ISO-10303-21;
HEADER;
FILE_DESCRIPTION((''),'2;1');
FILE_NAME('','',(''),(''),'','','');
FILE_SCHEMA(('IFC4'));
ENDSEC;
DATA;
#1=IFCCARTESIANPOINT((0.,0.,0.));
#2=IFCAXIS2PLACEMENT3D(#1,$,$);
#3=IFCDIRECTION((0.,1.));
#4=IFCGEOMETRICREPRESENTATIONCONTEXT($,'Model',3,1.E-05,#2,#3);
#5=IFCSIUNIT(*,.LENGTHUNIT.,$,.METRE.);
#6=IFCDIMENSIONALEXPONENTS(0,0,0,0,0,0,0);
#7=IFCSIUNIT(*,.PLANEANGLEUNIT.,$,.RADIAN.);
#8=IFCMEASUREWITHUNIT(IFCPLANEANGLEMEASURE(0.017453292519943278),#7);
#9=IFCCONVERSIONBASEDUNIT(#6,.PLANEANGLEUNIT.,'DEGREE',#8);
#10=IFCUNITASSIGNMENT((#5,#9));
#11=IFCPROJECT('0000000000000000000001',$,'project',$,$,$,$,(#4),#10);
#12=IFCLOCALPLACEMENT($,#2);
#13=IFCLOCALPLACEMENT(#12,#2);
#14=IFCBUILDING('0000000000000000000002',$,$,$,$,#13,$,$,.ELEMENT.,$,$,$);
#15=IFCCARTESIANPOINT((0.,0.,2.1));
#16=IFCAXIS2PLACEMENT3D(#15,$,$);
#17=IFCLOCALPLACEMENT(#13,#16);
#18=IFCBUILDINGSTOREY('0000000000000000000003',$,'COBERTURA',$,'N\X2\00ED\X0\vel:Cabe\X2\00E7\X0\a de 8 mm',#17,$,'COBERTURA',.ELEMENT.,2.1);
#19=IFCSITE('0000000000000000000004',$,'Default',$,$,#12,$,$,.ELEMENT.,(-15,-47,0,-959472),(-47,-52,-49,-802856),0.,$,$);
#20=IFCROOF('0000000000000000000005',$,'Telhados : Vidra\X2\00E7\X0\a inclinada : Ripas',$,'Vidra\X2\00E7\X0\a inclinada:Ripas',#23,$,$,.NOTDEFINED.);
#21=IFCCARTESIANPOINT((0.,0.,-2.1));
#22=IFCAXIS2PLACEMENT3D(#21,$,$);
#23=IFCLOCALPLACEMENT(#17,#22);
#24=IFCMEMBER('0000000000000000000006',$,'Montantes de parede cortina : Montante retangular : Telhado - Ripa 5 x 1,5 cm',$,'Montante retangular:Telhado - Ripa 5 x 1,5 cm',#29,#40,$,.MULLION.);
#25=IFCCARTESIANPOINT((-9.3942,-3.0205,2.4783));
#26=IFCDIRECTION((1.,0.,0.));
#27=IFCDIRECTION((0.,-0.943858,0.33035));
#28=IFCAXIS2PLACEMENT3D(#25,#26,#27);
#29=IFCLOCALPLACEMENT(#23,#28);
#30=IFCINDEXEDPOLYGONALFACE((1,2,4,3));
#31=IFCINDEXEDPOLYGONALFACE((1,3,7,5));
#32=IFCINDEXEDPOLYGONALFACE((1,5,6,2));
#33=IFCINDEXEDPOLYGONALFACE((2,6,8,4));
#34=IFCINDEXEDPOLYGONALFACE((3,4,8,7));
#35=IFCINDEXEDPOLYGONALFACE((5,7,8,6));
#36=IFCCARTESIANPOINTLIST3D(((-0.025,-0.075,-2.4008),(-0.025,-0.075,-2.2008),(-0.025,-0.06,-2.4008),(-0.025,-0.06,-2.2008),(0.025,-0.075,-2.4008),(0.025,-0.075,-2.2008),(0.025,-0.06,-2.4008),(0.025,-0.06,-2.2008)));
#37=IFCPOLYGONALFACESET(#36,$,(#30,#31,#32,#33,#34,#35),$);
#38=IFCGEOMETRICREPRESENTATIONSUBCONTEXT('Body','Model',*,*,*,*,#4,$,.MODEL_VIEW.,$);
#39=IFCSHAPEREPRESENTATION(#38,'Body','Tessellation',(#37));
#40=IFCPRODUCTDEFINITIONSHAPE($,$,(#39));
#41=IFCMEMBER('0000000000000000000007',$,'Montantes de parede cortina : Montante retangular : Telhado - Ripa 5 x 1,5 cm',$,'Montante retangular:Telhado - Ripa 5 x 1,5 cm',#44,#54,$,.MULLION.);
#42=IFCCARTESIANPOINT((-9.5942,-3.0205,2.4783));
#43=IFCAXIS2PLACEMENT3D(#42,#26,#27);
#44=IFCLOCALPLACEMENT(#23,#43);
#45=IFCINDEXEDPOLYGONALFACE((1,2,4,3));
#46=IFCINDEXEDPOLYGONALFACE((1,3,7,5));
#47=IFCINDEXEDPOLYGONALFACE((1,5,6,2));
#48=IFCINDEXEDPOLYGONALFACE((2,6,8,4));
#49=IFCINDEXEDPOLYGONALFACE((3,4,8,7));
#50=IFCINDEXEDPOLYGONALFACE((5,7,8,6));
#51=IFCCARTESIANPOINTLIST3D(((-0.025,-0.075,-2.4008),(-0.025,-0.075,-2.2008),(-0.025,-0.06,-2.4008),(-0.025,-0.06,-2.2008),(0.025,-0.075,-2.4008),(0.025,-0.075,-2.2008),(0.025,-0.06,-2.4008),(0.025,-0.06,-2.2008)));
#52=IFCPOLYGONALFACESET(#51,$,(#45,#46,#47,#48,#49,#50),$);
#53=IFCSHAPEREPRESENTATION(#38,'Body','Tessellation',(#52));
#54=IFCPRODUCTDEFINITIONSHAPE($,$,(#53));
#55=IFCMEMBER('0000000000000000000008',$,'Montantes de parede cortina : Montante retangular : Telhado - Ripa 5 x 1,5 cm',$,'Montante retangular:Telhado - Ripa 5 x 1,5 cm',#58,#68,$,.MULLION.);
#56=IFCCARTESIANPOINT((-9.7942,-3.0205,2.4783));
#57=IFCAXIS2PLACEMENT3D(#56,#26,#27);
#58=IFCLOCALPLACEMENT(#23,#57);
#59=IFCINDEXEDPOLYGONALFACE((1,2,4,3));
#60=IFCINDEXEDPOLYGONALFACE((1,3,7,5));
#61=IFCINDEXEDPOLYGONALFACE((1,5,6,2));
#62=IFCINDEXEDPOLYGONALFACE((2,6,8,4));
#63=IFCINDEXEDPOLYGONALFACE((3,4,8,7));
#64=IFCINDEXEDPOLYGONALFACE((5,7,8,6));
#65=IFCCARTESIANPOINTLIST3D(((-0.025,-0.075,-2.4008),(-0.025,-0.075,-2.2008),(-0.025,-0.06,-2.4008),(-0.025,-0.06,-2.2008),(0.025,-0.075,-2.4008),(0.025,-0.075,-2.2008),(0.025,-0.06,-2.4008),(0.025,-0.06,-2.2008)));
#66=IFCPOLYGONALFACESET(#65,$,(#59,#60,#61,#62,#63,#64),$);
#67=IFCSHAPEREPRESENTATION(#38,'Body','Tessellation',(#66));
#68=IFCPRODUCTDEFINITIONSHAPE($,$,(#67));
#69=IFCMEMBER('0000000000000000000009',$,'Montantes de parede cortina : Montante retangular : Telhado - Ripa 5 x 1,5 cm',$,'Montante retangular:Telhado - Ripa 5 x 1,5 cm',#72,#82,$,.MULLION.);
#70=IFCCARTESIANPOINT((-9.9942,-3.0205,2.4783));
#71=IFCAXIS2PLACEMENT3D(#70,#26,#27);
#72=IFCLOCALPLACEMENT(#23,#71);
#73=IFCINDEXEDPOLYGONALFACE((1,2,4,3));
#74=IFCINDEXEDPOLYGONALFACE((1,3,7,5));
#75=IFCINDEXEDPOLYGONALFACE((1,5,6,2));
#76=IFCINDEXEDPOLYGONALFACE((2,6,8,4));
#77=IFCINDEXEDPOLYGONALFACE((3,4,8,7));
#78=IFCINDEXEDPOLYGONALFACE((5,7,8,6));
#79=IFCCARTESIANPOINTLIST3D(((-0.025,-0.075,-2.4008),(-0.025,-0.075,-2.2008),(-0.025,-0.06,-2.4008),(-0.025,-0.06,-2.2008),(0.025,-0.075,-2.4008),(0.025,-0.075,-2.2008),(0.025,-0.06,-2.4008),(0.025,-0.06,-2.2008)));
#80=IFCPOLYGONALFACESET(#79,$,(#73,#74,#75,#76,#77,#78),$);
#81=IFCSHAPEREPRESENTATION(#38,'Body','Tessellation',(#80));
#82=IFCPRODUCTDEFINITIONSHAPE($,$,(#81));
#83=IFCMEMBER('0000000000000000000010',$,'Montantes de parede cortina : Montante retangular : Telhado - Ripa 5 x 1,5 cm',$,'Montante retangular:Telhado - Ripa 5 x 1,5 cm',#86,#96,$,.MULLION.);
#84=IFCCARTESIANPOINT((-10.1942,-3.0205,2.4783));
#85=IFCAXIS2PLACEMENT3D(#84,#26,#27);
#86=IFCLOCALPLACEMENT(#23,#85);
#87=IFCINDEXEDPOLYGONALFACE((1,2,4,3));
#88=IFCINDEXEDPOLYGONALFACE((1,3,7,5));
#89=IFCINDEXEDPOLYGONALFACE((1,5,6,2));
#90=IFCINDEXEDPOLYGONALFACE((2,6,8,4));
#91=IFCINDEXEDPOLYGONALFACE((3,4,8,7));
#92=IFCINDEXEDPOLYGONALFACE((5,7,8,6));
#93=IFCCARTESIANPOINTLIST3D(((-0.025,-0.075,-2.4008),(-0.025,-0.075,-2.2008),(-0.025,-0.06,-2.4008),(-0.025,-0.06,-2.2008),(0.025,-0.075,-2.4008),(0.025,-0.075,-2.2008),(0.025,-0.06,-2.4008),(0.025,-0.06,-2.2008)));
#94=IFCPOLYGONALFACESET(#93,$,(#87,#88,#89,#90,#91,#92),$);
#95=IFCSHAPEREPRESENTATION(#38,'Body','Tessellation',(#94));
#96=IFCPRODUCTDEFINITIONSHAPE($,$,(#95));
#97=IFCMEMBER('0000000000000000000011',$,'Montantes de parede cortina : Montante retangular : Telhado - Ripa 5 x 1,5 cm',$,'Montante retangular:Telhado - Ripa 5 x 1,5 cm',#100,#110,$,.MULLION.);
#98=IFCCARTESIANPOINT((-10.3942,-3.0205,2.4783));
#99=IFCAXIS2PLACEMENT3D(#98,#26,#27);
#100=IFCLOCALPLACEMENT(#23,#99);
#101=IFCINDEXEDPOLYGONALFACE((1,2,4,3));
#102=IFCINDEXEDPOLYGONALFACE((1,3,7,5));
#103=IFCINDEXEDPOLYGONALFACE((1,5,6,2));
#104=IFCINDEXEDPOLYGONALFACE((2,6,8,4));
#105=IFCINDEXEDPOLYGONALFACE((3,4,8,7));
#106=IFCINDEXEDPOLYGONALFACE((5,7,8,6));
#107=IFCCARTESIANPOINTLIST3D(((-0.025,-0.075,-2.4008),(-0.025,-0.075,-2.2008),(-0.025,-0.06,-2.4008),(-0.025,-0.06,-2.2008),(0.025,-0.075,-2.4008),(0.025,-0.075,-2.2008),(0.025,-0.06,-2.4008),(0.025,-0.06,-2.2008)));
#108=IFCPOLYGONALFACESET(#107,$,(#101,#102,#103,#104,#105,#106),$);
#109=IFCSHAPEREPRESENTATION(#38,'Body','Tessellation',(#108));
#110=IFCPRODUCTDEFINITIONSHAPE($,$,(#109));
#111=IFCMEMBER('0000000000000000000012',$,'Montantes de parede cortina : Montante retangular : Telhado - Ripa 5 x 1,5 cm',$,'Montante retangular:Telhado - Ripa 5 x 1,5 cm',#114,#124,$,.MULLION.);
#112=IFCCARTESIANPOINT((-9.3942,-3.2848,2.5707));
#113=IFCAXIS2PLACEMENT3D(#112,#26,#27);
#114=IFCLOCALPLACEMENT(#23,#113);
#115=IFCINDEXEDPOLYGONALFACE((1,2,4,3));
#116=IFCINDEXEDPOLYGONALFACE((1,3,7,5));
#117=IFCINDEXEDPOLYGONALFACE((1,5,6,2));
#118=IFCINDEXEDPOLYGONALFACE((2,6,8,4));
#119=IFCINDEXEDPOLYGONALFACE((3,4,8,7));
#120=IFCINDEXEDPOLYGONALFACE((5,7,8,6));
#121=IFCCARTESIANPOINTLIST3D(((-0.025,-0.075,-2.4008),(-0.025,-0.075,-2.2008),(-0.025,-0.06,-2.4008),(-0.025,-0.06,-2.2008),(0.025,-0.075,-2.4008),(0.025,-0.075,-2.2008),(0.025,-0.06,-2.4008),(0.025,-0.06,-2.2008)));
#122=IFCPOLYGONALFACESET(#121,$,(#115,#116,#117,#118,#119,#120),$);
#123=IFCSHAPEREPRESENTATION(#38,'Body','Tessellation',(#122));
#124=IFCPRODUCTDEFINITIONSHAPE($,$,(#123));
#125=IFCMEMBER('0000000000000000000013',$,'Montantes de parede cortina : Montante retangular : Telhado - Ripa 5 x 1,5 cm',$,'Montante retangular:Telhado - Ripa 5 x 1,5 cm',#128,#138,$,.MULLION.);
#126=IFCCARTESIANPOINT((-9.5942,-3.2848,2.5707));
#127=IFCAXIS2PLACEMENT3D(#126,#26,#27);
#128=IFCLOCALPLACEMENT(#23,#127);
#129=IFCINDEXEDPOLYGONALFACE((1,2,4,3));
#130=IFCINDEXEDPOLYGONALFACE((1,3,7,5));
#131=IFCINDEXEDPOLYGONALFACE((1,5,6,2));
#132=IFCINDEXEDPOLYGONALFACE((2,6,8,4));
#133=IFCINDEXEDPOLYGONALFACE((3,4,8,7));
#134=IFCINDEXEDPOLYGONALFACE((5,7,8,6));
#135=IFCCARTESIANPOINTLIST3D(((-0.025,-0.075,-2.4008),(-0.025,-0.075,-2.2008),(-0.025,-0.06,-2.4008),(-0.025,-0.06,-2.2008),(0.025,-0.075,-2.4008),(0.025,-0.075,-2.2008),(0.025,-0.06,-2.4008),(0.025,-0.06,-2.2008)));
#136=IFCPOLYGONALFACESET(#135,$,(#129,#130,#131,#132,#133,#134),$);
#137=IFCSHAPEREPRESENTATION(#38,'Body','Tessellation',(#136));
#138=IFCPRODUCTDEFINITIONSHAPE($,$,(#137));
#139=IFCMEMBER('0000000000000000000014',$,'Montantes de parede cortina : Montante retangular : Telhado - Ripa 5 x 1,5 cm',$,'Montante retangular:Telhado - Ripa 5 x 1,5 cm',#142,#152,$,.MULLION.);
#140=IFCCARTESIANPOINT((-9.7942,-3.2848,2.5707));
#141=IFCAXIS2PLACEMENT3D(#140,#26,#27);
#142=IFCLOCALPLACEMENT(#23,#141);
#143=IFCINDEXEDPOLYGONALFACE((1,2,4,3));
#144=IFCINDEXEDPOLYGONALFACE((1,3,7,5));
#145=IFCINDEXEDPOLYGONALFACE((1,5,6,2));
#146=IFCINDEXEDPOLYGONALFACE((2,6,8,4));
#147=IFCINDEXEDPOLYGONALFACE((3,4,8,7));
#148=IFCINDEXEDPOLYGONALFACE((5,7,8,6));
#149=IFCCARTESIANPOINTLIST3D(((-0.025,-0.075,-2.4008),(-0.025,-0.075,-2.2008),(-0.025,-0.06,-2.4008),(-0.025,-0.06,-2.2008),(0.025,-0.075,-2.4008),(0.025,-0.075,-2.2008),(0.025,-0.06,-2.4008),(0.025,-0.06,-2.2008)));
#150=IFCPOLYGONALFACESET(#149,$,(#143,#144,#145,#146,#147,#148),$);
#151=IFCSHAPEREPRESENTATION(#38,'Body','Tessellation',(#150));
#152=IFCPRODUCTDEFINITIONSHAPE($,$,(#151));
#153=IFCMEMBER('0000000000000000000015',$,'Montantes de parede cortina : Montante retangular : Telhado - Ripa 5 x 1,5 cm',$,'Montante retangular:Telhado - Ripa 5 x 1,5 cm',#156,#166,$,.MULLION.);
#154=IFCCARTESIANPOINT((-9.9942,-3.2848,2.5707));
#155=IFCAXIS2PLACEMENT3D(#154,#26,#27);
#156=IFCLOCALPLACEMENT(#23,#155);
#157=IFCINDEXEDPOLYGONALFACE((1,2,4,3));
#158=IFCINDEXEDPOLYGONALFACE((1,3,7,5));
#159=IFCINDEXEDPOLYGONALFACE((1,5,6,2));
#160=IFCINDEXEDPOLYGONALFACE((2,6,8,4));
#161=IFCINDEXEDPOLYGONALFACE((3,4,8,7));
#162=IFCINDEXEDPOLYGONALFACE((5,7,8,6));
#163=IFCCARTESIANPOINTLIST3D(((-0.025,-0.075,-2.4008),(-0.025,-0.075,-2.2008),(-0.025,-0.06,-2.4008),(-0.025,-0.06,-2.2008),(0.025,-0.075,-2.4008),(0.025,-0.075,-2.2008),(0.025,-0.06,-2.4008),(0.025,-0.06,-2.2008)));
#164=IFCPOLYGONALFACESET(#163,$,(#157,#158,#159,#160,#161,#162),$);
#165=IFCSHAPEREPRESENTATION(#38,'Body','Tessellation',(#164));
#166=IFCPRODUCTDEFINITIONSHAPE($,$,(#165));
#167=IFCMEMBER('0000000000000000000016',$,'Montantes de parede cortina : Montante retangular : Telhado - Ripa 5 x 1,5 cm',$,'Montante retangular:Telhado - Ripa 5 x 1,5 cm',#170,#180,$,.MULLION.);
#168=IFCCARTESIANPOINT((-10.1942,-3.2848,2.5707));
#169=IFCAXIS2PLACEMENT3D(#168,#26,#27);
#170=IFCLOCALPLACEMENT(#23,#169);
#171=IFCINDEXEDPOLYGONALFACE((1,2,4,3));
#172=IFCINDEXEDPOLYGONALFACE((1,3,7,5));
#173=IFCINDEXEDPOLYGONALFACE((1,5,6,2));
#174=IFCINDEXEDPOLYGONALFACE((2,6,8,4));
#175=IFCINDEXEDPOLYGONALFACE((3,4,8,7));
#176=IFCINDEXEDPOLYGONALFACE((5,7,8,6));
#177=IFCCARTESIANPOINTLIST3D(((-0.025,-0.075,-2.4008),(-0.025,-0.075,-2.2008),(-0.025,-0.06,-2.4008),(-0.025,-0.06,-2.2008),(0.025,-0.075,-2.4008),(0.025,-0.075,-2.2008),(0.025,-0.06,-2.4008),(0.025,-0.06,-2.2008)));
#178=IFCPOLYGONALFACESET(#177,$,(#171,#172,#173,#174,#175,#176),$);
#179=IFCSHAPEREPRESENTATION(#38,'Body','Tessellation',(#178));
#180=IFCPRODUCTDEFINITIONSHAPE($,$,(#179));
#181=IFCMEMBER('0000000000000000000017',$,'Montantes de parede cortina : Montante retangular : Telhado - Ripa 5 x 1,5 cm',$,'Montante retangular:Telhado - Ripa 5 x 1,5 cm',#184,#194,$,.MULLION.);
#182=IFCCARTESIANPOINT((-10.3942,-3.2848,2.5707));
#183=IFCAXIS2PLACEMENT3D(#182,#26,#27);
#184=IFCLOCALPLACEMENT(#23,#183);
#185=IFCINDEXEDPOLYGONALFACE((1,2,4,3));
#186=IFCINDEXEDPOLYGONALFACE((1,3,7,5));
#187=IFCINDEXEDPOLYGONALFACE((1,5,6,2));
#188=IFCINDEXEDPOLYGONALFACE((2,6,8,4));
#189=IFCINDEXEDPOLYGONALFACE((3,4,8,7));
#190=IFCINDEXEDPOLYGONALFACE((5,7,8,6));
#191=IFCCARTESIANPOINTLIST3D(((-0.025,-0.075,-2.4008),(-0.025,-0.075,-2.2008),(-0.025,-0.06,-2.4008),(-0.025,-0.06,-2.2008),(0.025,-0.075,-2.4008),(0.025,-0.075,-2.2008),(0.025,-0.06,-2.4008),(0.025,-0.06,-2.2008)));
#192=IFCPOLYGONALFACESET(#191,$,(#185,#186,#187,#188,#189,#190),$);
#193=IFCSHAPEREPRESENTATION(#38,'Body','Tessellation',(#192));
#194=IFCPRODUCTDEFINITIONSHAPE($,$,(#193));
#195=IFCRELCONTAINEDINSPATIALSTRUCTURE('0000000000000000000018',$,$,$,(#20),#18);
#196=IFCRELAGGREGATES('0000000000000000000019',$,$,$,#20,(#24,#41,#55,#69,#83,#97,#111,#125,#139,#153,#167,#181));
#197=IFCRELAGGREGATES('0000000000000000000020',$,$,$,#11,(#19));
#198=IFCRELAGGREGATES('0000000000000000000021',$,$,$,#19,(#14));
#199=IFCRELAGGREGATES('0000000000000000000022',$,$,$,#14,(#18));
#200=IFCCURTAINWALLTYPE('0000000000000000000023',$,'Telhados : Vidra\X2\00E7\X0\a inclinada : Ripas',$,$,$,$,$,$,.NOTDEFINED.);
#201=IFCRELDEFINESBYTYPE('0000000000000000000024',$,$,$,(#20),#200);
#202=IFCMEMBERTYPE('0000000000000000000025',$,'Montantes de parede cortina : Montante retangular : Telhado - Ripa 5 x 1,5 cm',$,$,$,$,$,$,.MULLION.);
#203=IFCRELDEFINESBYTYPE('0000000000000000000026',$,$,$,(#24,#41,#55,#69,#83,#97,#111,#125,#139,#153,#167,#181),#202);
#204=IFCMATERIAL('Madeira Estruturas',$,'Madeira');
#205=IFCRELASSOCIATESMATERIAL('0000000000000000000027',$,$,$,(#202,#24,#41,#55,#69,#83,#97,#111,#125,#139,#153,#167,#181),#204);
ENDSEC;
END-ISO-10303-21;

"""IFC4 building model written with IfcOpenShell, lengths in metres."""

from ifc_helpers import new_model, entity, si_unit, converted_unit, direction, frame, origin, place, context, subcontext, project, spatial, indexed_curve, outline, extrude, source, transform, mapped, material, type_object, type_shapes, element, aggregate, save


model = new_model("IFC4")

# Units and contexts
model_context = context("Model", 3, precision=1e-05, world=origin(), true_north=direction((0.0, 1.0)))
body_context = subcontext(model_context, "Body", "Model", "MODEL_VIEW")
ifc_project = project(units=[si_unit("LENGTHUNIT", "METRE"), converted_unit("PLANEANGLEUNIT", "DEGREE", entity("IfcPlaneAngleMeasure", 0.017453292519943278), si_unit("PLANEANGLEUNIT", "RADIAN"), dimensions=[0, 0, 0, 0, 0, 0, 0])], contexts=[model_context])

# Site, building, storey
site_placement = place(None, origin())
site = spatial("IfcSite", under=ifc_project, at=site_placement, Name="Default", CompositionType="ELEMENT", RefLatitude=(-15, -47, 0, -959472), RefLongitude=(-47, -52, -49, -802856), RefElevation=0.0)
building_placement = place(site_placement, origin())
building = spatial("IfcBuilding", under=site, at=building_placement, CompositionType="ELEMENT")
storey_placement = place(building_placement, frame((0.0, 0.0, 2.1)))
storey = spatial("IfcBuildingStorey", under=building, at=storey_placement, Name="COBERTURA", ObjectType="Nível:Cabeça de 8 mm", LongName="COBERTURA", CompositionType="ELEMENT", Elevation=2.1)

# Roof, members
curtain_wall_type_1 = type_object("IfcCurtainWallType", Name="Telhados : Vidraça inclinada : Ripas", PredefinedType="NOTDEFINED")
roof_1_placement = place(storey_placement, frame((0.0, 0.0, -2.1)))
roof_1 = element("IfcRoof", 1, at=roof_1_placement, inside=storey, type_object=curtain_wall_type_1, Name="Telhados : Vidraça inclinada : Ripas", ObjectType="Vidraça inclinada:Ripas", PredefinedType="NOTDEFINED")
ifc_material_1 = material(Name="Madeira Estruturas", Category="Madeira")
member_type_1 = type_object("IfcMemberType", Name="Montantes de parede cortina : Montante retangular : Telhado - Ripa 5 x 1,5 cm", PredefinedType="MULLION", material=ifc_material_1)
shared_shape_1 = source(origin(), body_context, "Body", "SweptSolid", [
    extrude(outline(indexed_curve([(-0.025, -0.0075), (0.025, -0.0075), (0.025, 0.0075), (-0.025, 0.0075), (-0.025, -0.0075)], self_intersect=False)), frame((0.0, -0.0675, -2.4008), z_axis=(0.0, 0.0, 1.0), x_axis=(-1.0, 0.0, 0.0)), (0.0, 0.0, 1.0), 0.2),
])
type_shapes(member_type_1, [shared_shape_1])
member_1_placement = place(roof_1_placement, frame((-9.3942, -3.0205, 2.4783), z_axis=(1.0, 0.0, 0.0), x_axis=(0.0, -0.943858, 0.33035)))
member_1 = element("IfcMember", 2, at=member_1_placement, type_object=member_type_1, material=ifc_material_1, Name="Montantes de parede cortina : Montante retangular : Telhado - Ripa 5 x 1,5 cm", ObjectType="Montante retangular:Telhado - Ripa 5 x 1,5 cm", PredefinedType="MULLION", context=body_context, shape_type="MappedRepresentation", body=[
    mapped(shared_shape_1, transform((0.0, 0.0, 0.0), scale=1.0)),
])
member_2_placement = place(roof_1_placement, frame((-9.5942, -3.0205, 2.4783), z_axis=(1.0, 0.0, 0.0), x_axis=(0.0, -0.943858, 0.33035)))
member_2 = element("IfcMember", 3, at=member_2_placement, type_object=member_type_1, material=ifc_material_1, Name="Montantes de parede cortina : Montante retangular : Telhado - Ripa 5 x 1,5 cm", ObjectType="Montante retangular:Telhado - Ripa 5 x 1,5 cm", PredefinedType="MULLION", context=body_context, shape_type="MappedRepresentation", body=[
    mapped(shared_shape_1, transform((0.0, 0.0, 0.0), scale=1.0)),
])
member_3_placement = place(roof_1_placement, frame((-9.7942, -3.0205, 2.4783), z_axis=(1.0, 0.0, 0.0), x_axis=(0.0, -0.943858, 0.33035)))
member_3 = element("IfcMember", 4, at=member_3_placement, type_object=member_type_1, material=ifc_material_1, Name="Montantes de parede cortina : Montante retangular : Telhado - Ripa 5 x 1,5 cm", ObjectType="Montante retangular:Telhado - Ripa 5 x 1,5 cm", PredefinedType="MULLION", context=body_context, shape_type="MappedRepresentation", body=[
    mapped(shared_shape_1, transform((0.0, 0.0, 0.0), scale=1.0)),
])
member_4_placement = place(roof_1_placement, frame((-9.9942, -3.0205, 2.4783), z_axis=(1.0, 0.0, 0.0), x_axis=(0.0, -0.943858, 0.33035)))
member_4 = element("IfcMember", 5, at=member_4_placement, type_object=member_type_1, material=ifc_material_1, Name="Montantes de parede cortina : Montante retangular : Telhado - Ripa 5 x 1,5 cm", ObjectType="Montante retangular:Telhado - Ripa 5 x 1,5 cm", PredefinedType="MULLION", context=body_context, shape_type="MappedRepresentation", body=[
    mapped(shared_shape_1, transform((0.0, 0.0, 0.0), scale=1.0)),
])
member_5_placement = place(roof_1_placement, frame((-10.1942, -3.0205, 2.4783), z_axis=(1.0, 0.0, 0.0), x_axis=(0.0, -0.943858, 0.33035)))
member_5 = element("IfcMember", 6, at=member_5_placement, type_object=member_type_1, material=ifc_material_1, Name="Montantes de parede cortina : Montante retangular : Telhado - Ripa 5 x 1,5 cm", ObjectType="Montante retangular:Telhado - Ripa 5 x 1,5 cm", PredefinedType="MULLION", context=body_context, shape_type="MappedRepresentation", body=[
    mapped(shared_shape_1, transform((0.0, 0.0, 0.0), scale=1.0)),
])
member_6_placement = place(roof_1_placement, frame((-10.3942, -3.0205, 2.4783), z_axis=(1.0, 0.0, 0.0), x_axis=(0.0, -0.943858, 0.33035)))
member_6 = element("IfcMember", 7, at=member_6_placement, type_object=member_type_1, material=ifc_material_1, Name="Montantes de parede cortina : Montante retangular : Telhado - Ripa 5 x 1,5 cm", ObjectType="Montante retangular:Telhado - Ripa 5 x 1,5 cm", PredefinedType="MULLION", context=body_context, shape_type="MappedRepresentation", body=[
    mapped(shared_shape_1, transform((0.0, 0.0, 0.0), scale=1.0)),
])
member_7_placement = place(roof_1_placement, frame((-9.3942, -3.2848, 2.5707), z_axis=(1.0, 0.0, 0.0), x_axis=(0.0, -0.943858, 0.33035)))
member_7 = element("IfcMember", 8, at=member_7_placement, type_object=member_type_1, material=ifc_material_1, Name="Montantes de parede cortina : Montante retangular : Telhado - Ripa 5 x 1,5 cm", ObjectType="Montante retangular:Telhado - Ripa 5 x 1,5 cm", PredefinedType="MULLION", context=body_context, shape_type="MappedRepresentation", body=[
    mapped(shared_shape_1, transform((0.0, 0.0, 0.0), scale=1.0)),
])
member_8_placement = place(roof_1_placement, frame((-9.5942, -3.2848, 2.5707), z_axis=(1.0, 0.0, 0.0), x_axis=(0.0, -0.943858, 0.33035)))
member_8 = element("IfcMember", 9, at=member_8_placement, type_object=member_type_1, material=ifc_material_1, Name="Montantes de parede cortina : Montante retangular : Telhado - Ripa 5 x 1,5 cm", ObjectType="Montante retangular:Telhado - Ripa 5 x 1,5 cm", PredefinedType="MULLION", context=body_context, shape_type="MappedRepresentation", body=[
    mapped(shared_shape_1, transform((0.0, 0.0, 0.0), scale=1.0)),
])
member_9_placement = place(roof_1_placement, frame((-9.7942, -3.2848, 2.5707), z_axis=(1.0, 0.0, 0.0), x_axis=(0.0, -0.943858, 0.33035)))
member_9 = element("IfcMember", 10, at=member_9_placement, type_object=member_type_1, material=ifc_material_1, Name="Montantes de parede cortina : Montante retangular : Telhado - Ripa 5 x 1,5 cm", ObjectType="Montante retangular:Telhado - Ripa 5 x 1,5 cm", PredefinedType="MULLION", context=body_context, shape_type="MappedRepresentation", body=[
    mapped(shared_shape_1, transform((0.0, 0.0, 0.0), scale=1.0)),
])
member_10_placement = place(roof_1_placement, frame((-9.9942, -3.2848, 2.5707), z_axis=(1.0, 0.0, 0.0), x_axis=(0.0, -0.943858, 0.33035)))
member_10 = element("IfcMember", 11, at=member_10_placement, type_object=member_type_1, material=ifc_material_1, Name="Montantes de parede cortina : Montante retangular : Telhado - Ripa 5 x 1,5 cm", ObjectType="Montante retangular:Telhado - Ripa 5 x 1,5 cm", PredefinedType="MULLION", context=body_context, shape_type="MappedRepresentation", body=[
    mapped(shared_shape_1, transform((0.0, 0.0, 0.0), scale=1.0)),
])
member_11_placement = place(roof_1_placement, frame((-10.1942, -3.2848, 2.5707), z_axis=(1.0, 0.0, 0.0), x_axis=(0.0, -0.943858, 0.33035)))
member_11 = element("IfcMember", 12, at=member_11_placement, type_object=member_type_1, material=ifc_material_1, Name="Montantes de parede cortina : Montante retangular : Telhado - Ripa 5 x 1,5 cm", ObjectType="Montante retangular:Telhado - Ripa 5 x 1,5 cm", PredefinedType="MULLION", context=body_context, shape_type="MappedRepresentation", body=[
    mapped(shared_shape_1, transform((0.0, 0.0, 0.0), scale=1.0)),
])
member_12_placement = place(roof_1_placement, frame((-10.3942, -3.2848, 2.5707), z_axis=(1.0, 0.0, 0.0), x_axis=(0.0, -0.943858, 0.33035)))
member_12 = element("IfcMember", 13, at=member_12_placement, type_object=member_type_1, material=ifc_material_1, Name="Montantes de parede cortina : Montante retangular : Telhado - Ripa 5 x 1,5 cm", ObjectType="Montante retangular:Telhado - Ripa 5 x 1,5 cm", PredefinedType="MULLION", context=body_context, shape_type="MappedRepresentation", body=[
    mapped(shared_shape_1, transform((0.0, 0.0, 0.0), scale=1.0)),
])
aggregate(roof_1, [member_1, member_2, member_3, member_4, member_5, member_6, member_7, member_8, member_9, member_10, member_11, member_12])

save(model, "model.ifc")
